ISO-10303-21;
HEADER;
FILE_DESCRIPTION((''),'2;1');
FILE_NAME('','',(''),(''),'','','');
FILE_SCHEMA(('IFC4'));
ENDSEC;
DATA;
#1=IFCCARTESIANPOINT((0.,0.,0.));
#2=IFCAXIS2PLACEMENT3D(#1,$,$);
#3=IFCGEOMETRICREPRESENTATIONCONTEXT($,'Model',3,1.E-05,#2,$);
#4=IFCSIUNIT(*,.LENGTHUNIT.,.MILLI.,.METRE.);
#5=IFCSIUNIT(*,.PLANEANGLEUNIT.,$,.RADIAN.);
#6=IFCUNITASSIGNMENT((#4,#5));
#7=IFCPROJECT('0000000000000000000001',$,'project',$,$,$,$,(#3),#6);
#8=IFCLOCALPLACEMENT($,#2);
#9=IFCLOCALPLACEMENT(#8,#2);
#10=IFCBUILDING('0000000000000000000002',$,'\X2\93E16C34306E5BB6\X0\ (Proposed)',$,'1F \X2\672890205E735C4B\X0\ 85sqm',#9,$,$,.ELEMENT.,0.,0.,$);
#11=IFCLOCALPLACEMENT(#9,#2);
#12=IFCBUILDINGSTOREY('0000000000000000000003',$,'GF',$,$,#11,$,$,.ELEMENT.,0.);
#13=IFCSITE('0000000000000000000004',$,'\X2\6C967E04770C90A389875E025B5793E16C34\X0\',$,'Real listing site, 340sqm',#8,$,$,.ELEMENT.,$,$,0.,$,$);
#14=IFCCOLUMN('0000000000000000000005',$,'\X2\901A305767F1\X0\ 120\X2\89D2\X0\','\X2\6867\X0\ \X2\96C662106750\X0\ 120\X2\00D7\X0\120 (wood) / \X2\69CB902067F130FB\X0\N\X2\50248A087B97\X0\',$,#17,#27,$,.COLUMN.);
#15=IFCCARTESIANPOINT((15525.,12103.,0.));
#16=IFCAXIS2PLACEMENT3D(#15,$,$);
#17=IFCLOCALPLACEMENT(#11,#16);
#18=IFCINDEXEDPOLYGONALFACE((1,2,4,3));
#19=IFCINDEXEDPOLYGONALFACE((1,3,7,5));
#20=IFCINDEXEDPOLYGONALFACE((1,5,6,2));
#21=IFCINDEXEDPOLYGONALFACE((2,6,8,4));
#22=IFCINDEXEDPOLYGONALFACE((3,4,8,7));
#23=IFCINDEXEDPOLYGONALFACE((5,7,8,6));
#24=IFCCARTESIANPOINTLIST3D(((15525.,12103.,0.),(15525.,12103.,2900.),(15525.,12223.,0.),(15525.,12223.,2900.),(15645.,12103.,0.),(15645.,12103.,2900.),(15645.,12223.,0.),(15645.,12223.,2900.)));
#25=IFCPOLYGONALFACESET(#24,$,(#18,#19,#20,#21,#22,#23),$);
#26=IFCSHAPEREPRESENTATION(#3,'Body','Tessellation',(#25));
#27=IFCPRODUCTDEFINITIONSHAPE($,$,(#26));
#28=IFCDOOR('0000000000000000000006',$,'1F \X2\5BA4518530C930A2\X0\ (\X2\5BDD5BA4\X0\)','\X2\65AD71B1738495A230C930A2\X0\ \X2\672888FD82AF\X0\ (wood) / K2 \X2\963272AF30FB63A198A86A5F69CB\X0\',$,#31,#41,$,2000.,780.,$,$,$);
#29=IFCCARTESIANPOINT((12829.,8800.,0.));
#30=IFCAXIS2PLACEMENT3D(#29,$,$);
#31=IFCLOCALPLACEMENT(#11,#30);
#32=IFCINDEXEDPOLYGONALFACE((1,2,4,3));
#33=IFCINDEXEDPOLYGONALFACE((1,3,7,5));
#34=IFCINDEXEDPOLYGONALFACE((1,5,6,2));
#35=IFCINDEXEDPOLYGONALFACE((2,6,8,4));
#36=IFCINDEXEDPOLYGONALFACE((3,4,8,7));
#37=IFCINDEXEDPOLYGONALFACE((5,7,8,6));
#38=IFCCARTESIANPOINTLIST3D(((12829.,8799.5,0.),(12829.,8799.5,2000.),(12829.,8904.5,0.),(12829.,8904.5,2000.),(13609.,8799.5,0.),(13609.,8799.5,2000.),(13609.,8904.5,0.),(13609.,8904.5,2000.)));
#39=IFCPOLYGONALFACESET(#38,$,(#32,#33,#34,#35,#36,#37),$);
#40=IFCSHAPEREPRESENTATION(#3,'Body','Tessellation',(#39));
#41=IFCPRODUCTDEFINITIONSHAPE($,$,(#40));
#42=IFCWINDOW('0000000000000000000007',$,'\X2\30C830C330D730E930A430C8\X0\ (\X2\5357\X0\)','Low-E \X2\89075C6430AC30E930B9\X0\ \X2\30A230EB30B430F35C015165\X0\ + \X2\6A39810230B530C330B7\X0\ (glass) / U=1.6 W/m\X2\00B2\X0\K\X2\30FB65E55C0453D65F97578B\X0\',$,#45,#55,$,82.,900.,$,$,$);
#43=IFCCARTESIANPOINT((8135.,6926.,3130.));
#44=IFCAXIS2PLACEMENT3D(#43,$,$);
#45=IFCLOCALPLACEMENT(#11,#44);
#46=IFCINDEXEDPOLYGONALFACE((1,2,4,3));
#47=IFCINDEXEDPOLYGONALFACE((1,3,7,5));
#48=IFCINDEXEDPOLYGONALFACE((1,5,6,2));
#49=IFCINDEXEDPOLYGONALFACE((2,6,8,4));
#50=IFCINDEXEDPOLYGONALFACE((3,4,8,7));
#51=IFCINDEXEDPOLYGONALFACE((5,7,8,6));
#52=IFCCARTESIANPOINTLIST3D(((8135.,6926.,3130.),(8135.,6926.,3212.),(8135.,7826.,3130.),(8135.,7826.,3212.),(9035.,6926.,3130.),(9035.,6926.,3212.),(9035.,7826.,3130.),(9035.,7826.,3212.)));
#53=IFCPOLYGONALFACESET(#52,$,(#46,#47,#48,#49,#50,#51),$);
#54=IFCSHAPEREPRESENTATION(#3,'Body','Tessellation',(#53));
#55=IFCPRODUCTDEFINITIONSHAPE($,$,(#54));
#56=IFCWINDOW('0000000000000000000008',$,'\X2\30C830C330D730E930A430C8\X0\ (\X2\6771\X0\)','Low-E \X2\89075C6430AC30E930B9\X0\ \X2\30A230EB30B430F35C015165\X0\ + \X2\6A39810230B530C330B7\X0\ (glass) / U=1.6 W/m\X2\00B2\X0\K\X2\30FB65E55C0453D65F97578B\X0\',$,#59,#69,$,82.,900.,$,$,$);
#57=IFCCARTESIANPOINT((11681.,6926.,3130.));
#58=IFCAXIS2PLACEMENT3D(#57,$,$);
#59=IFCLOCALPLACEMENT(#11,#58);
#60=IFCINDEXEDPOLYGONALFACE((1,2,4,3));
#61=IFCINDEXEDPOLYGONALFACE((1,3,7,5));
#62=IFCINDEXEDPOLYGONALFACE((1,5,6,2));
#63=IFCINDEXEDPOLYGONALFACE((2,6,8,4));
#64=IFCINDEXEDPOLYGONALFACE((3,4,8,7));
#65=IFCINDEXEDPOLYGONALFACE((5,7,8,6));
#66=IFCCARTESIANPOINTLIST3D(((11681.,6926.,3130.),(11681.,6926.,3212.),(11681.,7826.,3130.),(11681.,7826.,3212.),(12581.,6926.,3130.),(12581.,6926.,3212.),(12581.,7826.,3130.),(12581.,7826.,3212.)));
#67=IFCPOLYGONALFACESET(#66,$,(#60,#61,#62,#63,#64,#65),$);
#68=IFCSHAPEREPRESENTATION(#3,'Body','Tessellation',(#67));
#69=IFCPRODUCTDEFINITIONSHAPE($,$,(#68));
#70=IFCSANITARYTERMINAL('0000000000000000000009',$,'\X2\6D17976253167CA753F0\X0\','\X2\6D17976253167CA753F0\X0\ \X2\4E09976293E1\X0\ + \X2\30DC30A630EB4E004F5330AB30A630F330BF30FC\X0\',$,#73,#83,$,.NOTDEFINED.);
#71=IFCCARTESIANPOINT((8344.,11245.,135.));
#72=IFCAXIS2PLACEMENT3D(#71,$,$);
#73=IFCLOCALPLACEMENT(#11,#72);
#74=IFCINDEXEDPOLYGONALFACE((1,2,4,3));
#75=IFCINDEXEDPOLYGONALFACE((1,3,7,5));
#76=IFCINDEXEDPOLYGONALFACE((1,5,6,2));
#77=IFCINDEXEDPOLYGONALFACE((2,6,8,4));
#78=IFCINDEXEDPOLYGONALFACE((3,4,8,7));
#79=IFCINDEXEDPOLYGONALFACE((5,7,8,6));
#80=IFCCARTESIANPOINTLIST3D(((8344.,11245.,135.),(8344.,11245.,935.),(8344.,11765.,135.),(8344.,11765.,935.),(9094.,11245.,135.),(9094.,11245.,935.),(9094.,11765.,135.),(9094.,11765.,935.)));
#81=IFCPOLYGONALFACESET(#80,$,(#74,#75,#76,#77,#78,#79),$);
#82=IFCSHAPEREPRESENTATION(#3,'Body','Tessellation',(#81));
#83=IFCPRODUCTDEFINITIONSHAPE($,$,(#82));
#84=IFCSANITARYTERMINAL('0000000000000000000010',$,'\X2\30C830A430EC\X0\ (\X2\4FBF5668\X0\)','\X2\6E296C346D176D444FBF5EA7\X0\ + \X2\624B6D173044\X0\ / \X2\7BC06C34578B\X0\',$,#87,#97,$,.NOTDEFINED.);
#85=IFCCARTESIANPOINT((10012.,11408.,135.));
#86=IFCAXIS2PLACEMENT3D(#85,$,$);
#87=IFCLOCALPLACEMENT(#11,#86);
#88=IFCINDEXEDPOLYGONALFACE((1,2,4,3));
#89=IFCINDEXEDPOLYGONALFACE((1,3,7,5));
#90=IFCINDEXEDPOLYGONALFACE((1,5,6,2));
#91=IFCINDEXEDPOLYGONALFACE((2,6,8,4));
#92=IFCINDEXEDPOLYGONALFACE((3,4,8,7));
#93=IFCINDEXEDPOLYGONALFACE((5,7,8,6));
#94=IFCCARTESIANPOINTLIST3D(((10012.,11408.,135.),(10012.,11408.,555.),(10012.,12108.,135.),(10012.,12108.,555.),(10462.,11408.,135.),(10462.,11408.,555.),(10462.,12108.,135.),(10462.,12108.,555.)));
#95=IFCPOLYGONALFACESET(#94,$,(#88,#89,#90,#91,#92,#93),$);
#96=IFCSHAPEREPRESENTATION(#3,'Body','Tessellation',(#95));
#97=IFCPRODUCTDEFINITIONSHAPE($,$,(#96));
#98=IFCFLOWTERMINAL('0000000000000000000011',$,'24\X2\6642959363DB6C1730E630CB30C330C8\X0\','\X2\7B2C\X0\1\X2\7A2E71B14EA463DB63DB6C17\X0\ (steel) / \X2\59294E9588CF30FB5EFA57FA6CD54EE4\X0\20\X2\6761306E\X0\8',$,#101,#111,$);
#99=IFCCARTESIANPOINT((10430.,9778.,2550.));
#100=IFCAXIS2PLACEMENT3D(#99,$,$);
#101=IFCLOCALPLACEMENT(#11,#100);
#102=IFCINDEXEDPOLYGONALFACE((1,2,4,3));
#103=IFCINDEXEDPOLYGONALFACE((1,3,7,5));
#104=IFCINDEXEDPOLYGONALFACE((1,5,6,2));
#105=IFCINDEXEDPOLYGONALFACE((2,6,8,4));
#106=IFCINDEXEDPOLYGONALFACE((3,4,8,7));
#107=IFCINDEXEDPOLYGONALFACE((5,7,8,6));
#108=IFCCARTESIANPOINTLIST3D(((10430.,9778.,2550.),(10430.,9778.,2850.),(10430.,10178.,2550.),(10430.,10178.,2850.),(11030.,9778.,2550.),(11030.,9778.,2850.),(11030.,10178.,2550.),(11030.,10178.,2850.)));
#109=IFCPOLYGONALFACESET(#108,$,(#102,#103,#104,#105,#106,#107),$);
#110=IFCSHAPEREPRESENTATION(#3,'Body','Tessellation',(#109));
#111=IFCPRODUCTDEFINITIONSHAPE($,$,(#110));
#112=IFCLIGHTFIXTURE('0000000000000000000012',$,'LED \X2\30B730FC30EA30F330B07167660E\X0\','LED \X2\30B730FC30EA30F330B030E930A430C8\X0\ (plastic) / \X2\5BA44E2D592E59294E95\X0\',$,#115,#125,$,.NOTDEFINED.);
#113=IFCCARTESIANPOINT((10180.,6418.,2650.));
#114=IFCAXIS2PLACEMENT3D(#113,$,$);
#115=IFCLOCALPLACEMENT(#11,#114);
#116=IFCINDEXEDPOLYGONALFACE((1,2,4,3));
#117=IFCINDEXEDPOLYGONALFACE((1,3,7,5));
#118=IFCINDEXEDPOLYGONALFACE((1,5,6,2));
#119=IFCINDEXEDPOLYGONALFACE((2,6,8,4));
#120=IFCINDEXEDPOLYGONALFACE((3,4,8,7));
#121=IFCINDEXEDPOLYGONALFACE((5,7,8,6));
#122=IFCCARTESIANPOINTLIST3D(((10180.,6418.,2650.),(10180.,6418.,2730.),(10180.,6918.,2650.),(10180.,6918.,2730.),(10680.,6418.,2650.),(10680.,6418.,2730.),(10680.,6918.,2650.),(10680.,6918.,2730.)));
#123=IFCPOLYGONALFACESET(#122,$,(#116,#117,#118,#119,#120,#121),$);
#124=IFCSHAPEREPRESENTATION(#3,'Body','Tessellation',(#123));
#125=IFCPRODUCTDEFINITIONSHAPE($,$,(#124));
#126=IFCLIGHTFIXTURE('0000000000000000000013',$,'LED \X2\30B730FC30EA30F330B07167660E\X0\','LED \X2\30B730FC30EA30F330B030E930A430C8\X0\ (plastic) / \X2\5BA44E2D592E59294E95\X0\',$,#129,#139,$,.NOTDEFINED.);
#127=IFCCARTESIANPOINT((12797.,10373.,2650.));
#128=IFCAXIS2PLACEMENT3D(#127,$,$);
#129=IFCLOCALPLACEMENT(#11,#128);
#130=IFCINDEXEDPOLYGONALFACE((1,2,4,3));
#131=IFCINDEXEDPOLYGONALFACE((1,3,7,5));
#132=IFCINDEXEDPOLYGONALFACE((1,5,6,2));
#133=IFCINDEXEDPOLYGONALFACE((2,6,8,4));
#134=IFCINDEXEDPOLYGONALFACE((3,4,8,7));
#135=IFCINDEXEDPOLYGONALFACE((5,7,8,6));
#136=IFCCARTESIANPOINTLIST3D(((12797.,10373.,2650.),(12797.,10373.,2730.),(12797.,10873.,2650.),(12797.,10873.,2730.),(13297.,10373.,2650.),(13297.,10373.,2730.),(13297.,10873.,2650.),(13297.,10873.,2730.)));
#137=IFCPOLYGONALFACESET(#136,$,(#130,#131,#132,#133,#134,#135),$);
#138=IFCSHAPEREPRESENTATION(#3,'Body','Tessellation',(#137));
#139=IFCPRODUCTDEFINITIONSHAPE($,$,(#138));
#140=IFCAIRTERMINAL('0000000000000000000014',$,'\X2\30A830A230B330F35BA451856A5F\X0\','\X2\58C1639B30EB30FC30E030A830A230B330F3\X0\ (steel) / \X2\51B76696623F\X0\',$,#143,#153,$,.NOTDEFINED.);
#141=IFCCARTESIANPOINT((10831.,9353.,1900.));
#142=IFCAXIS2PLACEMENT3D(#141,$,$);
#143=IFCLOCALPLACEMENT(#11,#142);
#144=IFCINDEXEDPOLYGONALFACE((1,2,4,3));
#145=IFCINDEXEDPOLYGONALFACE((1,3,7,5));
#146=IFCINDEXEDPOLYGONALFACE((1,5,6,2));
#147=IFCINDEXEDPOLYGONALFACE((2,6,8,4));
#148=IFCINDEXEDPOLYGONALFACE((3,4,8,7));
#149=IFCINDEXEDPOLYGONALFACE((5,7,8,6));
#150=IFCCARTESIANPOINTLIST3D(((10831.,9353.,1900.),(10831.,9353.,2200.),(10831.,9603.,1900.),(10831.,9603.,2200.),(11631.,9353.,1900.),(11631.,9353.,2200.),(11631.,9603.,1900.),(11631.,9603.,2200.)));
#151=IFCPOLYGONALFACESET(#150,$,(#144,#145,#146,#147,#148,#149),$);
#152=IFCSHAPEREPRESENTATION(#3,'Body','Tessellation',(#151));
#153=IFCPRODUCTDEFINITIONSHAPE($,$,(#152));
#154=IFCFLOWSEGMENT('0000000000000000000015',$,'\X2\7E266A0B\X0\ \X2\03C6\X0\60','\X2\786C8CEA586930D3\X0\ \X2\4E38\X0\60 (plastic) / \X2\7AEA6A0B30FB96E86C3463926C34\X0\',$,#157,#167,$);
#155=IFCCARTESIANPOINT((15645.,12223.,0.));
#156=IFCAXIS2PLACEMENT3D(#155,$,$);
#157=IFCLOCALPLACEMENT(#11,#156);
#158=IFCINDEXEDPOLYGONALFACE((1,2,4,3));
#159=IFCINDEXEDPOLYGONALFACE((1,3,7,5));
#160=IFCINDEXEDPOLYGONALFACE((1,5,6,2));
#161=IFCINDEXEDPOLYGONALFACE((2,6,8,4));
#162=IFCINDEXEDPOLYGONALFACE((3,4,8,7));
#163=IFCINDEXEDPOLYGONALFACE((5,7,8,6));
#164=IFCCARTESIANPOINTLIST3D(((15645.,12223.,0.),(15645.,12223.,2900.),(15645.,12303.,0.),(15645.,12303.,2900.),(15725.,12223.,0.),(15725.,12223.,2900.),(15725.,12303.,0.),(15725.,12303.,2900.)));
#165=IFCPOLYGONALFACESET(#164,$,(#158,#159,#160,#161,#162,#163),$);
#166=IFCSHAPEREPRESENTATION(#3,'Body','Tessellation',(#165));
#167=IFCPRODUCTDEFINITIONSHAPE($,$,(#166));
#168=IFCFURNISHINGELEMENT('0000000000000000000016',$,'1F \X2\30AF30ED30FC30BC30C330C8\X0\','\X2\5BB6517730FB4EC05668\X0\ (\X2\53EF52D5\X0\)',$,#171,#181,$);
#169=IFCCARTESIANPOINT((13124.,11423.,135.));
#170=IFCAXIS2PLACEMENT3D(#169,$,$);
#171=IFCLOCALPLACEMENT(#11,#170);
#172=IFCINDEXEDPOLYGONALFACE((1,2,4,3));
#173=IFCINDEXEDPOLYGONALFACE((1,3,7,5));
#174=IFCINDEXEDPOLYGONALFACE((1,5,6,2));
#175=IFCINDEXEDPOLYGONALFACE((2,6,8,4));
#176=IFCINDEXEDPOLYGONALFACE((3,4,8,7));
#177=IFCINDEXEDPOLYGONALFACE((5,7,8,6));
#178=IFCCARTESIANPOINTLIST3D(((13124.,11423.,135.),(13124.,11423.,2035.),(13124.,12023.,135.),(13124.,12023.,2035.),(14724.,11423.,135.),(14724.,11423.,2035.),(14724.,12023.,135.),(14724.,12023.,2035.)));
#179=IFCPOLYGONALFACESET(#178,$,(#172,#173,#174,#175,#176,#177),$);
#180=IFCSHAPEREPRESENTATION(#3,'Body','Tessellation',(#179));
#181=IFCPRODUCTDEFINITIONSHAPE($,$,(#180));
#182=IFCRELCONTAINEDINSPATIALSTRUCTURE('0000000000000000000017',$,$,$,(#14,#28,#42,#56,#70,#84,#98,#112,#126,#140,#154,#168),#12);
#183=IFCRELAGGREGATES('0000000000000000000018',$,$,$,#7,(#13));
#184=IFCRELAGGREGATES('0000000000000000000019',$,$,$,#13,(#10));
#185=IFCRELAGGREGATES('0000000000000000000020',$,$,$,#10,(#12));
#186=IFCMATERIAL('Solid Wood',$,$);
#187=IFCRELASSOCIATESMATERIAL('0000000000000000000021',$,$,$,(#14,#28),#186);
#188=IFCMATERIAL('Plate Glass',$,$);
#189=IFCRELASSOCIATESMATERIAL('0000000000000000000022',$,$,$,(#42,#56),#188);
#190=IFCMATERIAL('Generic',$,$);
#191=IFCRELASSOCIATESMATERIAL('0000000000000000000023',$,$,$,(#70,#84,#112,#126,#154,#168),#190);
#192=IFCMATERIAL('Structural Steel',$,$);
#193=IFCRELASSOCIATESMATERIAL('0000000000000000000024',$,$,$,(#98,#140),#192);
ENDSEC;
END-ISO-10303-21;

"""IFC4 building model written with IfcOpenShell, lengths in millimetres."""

from ifc_helpers import new_model, si_unit, frame, frame_2d, origin, place, context, project, spatial, rectangle, extrude, material, element, save


model = new_model("IFC4")

# Units and contexts
model_context = context("Model", 3, precision=1e-05, world=origin())
ifc_project = project(units=[si_unit("LENGTHUNIT", "METRE", prefix="MILLI"), si_unit("PLANEANGLEUNIT", "RADIAN")], contexts=[model_context])

# Site, building, storey
site_placement = place(None, origin())
site = spatial("IfcSite", under=ifc_project, at=site_placement, Name="沖縄県那覇市字鏡水", ObjectType="Real listing site, 340sqm", CompositionType="ELEMENT", RefElevation=0.0)
building_placement = place(site_placement, origin())
building = spatial("IfcBuilding", under=site, at=building_placement, Name="鏡水の家 (Proposed)", ObjectType="1F 木造平屋 85sqm", CompositionType="ELEMENT", ElevationOfRefHeight=0.0, ElevationOfTerrain=0.0)
storey_placement = place(building_placement, origin())
storey = spatial("IfcBuildingStorey", under=building, at=storey_placement, Name="GF", CompositionType="ELEMENT", Elevation=0.0)

# Column
ifc_material_1 = material(Name="Solid Wood")
column_1_placement = place(storey_placement, frame((15525.0, 12103.0, 0.0)))
element("IfcColumn", 1, at=column_1_placement, inside=storey, material=ifc_material_1, Name="通し柱 120角", Description="桧 集成材 120×120 (wood) / 構造柱・N値計算", PredefinedType="COLUMN", context=model_context, shape_type="SweptSolid", body=[
    extrude(rectangle(XDim=120.0, YDim=120.0, at=frame_2d((60.0, 60.0))), frame((15525.0, 12103.0, 0.0)), (0.0, 0.0, 1.0), 2900.0),
])

# Door
door_placement = place(storey_placement, frame((12829.0, 8800.0, 0.0)))
element("IfcDoor", 2, at=door_placement, inside=storey, material=ifc_material_1, Name="1F 室内ドア (寝室)", Description="断熱玄関ドア 木製芯 (wood) / K2 防犯・採風機構", OverallHeight=2000.0, OverallWidth=780.0, context=model_context, shape_type="SweptSolid", body=[
    extrude(rectangle(XDim=780.0, YDim=105.0, at=frame_2d((390.0, 52.0))), frame((12829.0, 8800.0, 0.0)), (0.0, 0.0, 1.0), 2000.0),
])

# Windows
ifc_material_2 = material(Name="Plate Glass")
window_1_placement = place(storey_placement, frame((8135.0, 6926.0, 3130.0)))
element("IfcWindow", 3, at=window_1_placement, inside=storey, material=ifc_material_2, Name="トップライト (南)", Description="Low-E 複層ガラス アルゴン封入 + 樹脂サッシ (glass) / U=1.6 W/m²K・日射取得型", OverallHeight=82.0, OverallWidth=900.0, context=model_context, shape_type="SweptSolid", body=[
    extrude(rectangle(XDim=900.0, YDim=900.0, at=frame_2d((450.0, 450.0))), frame((8135.0, 6926.0, 3130.0)), (0.0, 0.0, 1.0), 82.0),
])
window_2_placement = place(storey_placement, frame((11681.0, 6926.0, 3130.0)))
element("IfcWindow", 4, at=window_2_placement, inside=storey, material=ifc_material_2, Name="トップライト (東)", Description="Low-E 複層ガラス アルゴン封入 + 樹脂サッシ (glass) / U=1.6 W/m²K・日射取得型", OverallHeight=82.0, OverallWidth=900.0, context=model_context, shape_type="SweptSolid", body=[
    extrude(rectangle(XDim=900.0, YDim=900.0, at=frame_2d((450.0, 450.0))), frame((11681.0, 6926.0, 3130.0)), (0.0, 0.0, 1.0), 82.0),
])

# Sanitary terminals
ifc_material_3 = material(Name="Generic")
sanitary_terminal_1_placement = place(storey_placement, frame((8344.0, 11245.0, 135.0)))
element("IfcSanitaryTerminal", 5, at=sanitary_terminal_1_placement, inside=storey, material=ifc_material_3, Name="洗面化粧台", Description="洗面化粧台 三面鏡 + ボウル一体カウンター", PredefinedType="NOTDEFINED", context=model_context, shape_type="SweptSolid", body=[
    extrude(rectangle(XDim=750.0, YDim=520.0, at=frame_2d((375.0, 260.0))), frame((8344.0, 11245.0, 135.0)), (0.0, 0.0, 1.0), 800.0),
])
sanitary_terminal_2_placement = place(storey_placement, frame((10012.0, 11408.0, 135.0)))
element("IfcSanitaryTerminal", 6, at=sanitary_terminal_2_placement, inside=storey, material=ifc_material_3, Name="トイレ (便器)", Description="温水洗浄便座 + 手洗い / 節水型", PredefinedType="NOTDEFINED", context=model_context, shape_type="SweptSolid", body=[
    extrude(rectangle(XDim=450.0, YDim=700.0, at=frame_2d((225.0, 350.0))), frame((10012.0, 11408.0, 135.0)), (0.0, 0.0, 1.0), 420.0),
])

# Flow terminal
ifc_material_4 = material(Name="Structural Steel")
flow_terminal_placement = place(storey_placement, frame((10430.0, 9778.0, 2550.0)))
element("IfcFlowTerminal", 7, at=flow_terminal_placement, inside=storey, material=ifc_material_4, Name="24時間換気ユニット", Description="第1種熱交換換気 (steel) / 天井裏・建基法令20条の8", context=model_context, shape_type="SweptSolid", body=[
    extrude(rectangle(XDim=600.0, YDim=400.0, at=frame_2d((300.0, 200.0))), frame((10430.0, 9778.0, 2550.0)), (0.0, 0.0, 1.0), 300.0),
])

# Light fixtures
light_fixture_1_placement = place(storey_placement, frame((10180.0, 6418.0, 2650.0)))
element("IfcLightFixture", 8, at=light_fixture_1_placement, inside=storey, material=ifc_material_3, Name="LED シーリング照明", Description="LED シーリングライト (plastic) / 室中央天井", PredefinedType="NOTDEFINED", context=model_context, shape_type="SweptSolid", body=[
    extrude(rectangle(XDim=500.0, YDim=500.0, at=frame_2d((250.0, 250.0))), frame((10180.0, 6418.0, 2650.0)), (0.0, 0.0, 1.0), 80.0),
])
light_fixture_2_placement = place(storey_placement, frame((12797.0, 10373.0, 2650.0)))
element("IfcLightFixture", 9, at=light_fixture_2_placement, inside=storey, material=ifc_material_3, Name="LED シーリング照明", Description="LED シーリングライト (plastic) / 室中央天井", PredefinedType="NOTDEFINED", context=model_context, shape_type="SweptSolid", body=[
    extrude(rectangle(XDim=500.0, YDim=500.0, at=frame_2d((250.0, 250.0))), frame((12797.0, 10373.0, 2650.0)), (0.0, 0.0, 1.0), 80.0),
])

# Air terminal
air_terminal_placement = place(storey_placement, frame((10831.0, 9353.0, 1900.0)))
element("IfcAirTerminal", 10, at=air_terminal_placement, inside=storey, material=ifc_material_4, Name="エアコン室内機", Description="壁掛ルームエアコン (steel) / 冷暖房", PredefinedType="NOTDEFINED", context=model_context, shape_type="SweptSolid", body=[
    extrude(rectangle(XDim=800.0, YDim=250.0, at=frame_2d((400.0, 125.0))), frame((10831.0, 9353.0, 1900.0)), (0.0, 0.0, 1.0), 300.0),
])

# Flow segment
flow_segment_placement = place(storey_placement, frame((15645.0, 12223.0, 0.0)))
element("IfcFlowSegment", 11, at=flow_segment_placement, inside=storey, material=ifc_material_3, Name="縦樋 φ60", Description="硬質塩ビ 丸60 (plastic) / 竪樋・雨水排水", context=model_context, shape_type="SweptSolid", body=[
    extrude(rectangle(XDim=80.0, YDim=80.0, at=frame_2d((40.0, 40.0))), frame((15645.0, 12223.0, 0.0)), (0.0, 0.0, 1.0), 2900.0),
])

# Furnishing element
furnishing_placement = place(storey_placement, frame((13124.0, 11423.0, 135.0)))
element("IfcFurnishingElement", 12, at=furnishing_placement, inside=storey, material=ifc_material_3, Name="1F クローゼット", Description="家具・什器 (可動)", context=model_context, shape_type="SweptSolid", body=[
    extrude(rectangle(XDim=1600.0, YDim=600.0, at=frame_2d((800.0, 300.0))), frame((13124.0, 11423.0, 135.0)), (0.0, 0.0, 1.0), 1900.0),
])

save(model, "model.ifc")
